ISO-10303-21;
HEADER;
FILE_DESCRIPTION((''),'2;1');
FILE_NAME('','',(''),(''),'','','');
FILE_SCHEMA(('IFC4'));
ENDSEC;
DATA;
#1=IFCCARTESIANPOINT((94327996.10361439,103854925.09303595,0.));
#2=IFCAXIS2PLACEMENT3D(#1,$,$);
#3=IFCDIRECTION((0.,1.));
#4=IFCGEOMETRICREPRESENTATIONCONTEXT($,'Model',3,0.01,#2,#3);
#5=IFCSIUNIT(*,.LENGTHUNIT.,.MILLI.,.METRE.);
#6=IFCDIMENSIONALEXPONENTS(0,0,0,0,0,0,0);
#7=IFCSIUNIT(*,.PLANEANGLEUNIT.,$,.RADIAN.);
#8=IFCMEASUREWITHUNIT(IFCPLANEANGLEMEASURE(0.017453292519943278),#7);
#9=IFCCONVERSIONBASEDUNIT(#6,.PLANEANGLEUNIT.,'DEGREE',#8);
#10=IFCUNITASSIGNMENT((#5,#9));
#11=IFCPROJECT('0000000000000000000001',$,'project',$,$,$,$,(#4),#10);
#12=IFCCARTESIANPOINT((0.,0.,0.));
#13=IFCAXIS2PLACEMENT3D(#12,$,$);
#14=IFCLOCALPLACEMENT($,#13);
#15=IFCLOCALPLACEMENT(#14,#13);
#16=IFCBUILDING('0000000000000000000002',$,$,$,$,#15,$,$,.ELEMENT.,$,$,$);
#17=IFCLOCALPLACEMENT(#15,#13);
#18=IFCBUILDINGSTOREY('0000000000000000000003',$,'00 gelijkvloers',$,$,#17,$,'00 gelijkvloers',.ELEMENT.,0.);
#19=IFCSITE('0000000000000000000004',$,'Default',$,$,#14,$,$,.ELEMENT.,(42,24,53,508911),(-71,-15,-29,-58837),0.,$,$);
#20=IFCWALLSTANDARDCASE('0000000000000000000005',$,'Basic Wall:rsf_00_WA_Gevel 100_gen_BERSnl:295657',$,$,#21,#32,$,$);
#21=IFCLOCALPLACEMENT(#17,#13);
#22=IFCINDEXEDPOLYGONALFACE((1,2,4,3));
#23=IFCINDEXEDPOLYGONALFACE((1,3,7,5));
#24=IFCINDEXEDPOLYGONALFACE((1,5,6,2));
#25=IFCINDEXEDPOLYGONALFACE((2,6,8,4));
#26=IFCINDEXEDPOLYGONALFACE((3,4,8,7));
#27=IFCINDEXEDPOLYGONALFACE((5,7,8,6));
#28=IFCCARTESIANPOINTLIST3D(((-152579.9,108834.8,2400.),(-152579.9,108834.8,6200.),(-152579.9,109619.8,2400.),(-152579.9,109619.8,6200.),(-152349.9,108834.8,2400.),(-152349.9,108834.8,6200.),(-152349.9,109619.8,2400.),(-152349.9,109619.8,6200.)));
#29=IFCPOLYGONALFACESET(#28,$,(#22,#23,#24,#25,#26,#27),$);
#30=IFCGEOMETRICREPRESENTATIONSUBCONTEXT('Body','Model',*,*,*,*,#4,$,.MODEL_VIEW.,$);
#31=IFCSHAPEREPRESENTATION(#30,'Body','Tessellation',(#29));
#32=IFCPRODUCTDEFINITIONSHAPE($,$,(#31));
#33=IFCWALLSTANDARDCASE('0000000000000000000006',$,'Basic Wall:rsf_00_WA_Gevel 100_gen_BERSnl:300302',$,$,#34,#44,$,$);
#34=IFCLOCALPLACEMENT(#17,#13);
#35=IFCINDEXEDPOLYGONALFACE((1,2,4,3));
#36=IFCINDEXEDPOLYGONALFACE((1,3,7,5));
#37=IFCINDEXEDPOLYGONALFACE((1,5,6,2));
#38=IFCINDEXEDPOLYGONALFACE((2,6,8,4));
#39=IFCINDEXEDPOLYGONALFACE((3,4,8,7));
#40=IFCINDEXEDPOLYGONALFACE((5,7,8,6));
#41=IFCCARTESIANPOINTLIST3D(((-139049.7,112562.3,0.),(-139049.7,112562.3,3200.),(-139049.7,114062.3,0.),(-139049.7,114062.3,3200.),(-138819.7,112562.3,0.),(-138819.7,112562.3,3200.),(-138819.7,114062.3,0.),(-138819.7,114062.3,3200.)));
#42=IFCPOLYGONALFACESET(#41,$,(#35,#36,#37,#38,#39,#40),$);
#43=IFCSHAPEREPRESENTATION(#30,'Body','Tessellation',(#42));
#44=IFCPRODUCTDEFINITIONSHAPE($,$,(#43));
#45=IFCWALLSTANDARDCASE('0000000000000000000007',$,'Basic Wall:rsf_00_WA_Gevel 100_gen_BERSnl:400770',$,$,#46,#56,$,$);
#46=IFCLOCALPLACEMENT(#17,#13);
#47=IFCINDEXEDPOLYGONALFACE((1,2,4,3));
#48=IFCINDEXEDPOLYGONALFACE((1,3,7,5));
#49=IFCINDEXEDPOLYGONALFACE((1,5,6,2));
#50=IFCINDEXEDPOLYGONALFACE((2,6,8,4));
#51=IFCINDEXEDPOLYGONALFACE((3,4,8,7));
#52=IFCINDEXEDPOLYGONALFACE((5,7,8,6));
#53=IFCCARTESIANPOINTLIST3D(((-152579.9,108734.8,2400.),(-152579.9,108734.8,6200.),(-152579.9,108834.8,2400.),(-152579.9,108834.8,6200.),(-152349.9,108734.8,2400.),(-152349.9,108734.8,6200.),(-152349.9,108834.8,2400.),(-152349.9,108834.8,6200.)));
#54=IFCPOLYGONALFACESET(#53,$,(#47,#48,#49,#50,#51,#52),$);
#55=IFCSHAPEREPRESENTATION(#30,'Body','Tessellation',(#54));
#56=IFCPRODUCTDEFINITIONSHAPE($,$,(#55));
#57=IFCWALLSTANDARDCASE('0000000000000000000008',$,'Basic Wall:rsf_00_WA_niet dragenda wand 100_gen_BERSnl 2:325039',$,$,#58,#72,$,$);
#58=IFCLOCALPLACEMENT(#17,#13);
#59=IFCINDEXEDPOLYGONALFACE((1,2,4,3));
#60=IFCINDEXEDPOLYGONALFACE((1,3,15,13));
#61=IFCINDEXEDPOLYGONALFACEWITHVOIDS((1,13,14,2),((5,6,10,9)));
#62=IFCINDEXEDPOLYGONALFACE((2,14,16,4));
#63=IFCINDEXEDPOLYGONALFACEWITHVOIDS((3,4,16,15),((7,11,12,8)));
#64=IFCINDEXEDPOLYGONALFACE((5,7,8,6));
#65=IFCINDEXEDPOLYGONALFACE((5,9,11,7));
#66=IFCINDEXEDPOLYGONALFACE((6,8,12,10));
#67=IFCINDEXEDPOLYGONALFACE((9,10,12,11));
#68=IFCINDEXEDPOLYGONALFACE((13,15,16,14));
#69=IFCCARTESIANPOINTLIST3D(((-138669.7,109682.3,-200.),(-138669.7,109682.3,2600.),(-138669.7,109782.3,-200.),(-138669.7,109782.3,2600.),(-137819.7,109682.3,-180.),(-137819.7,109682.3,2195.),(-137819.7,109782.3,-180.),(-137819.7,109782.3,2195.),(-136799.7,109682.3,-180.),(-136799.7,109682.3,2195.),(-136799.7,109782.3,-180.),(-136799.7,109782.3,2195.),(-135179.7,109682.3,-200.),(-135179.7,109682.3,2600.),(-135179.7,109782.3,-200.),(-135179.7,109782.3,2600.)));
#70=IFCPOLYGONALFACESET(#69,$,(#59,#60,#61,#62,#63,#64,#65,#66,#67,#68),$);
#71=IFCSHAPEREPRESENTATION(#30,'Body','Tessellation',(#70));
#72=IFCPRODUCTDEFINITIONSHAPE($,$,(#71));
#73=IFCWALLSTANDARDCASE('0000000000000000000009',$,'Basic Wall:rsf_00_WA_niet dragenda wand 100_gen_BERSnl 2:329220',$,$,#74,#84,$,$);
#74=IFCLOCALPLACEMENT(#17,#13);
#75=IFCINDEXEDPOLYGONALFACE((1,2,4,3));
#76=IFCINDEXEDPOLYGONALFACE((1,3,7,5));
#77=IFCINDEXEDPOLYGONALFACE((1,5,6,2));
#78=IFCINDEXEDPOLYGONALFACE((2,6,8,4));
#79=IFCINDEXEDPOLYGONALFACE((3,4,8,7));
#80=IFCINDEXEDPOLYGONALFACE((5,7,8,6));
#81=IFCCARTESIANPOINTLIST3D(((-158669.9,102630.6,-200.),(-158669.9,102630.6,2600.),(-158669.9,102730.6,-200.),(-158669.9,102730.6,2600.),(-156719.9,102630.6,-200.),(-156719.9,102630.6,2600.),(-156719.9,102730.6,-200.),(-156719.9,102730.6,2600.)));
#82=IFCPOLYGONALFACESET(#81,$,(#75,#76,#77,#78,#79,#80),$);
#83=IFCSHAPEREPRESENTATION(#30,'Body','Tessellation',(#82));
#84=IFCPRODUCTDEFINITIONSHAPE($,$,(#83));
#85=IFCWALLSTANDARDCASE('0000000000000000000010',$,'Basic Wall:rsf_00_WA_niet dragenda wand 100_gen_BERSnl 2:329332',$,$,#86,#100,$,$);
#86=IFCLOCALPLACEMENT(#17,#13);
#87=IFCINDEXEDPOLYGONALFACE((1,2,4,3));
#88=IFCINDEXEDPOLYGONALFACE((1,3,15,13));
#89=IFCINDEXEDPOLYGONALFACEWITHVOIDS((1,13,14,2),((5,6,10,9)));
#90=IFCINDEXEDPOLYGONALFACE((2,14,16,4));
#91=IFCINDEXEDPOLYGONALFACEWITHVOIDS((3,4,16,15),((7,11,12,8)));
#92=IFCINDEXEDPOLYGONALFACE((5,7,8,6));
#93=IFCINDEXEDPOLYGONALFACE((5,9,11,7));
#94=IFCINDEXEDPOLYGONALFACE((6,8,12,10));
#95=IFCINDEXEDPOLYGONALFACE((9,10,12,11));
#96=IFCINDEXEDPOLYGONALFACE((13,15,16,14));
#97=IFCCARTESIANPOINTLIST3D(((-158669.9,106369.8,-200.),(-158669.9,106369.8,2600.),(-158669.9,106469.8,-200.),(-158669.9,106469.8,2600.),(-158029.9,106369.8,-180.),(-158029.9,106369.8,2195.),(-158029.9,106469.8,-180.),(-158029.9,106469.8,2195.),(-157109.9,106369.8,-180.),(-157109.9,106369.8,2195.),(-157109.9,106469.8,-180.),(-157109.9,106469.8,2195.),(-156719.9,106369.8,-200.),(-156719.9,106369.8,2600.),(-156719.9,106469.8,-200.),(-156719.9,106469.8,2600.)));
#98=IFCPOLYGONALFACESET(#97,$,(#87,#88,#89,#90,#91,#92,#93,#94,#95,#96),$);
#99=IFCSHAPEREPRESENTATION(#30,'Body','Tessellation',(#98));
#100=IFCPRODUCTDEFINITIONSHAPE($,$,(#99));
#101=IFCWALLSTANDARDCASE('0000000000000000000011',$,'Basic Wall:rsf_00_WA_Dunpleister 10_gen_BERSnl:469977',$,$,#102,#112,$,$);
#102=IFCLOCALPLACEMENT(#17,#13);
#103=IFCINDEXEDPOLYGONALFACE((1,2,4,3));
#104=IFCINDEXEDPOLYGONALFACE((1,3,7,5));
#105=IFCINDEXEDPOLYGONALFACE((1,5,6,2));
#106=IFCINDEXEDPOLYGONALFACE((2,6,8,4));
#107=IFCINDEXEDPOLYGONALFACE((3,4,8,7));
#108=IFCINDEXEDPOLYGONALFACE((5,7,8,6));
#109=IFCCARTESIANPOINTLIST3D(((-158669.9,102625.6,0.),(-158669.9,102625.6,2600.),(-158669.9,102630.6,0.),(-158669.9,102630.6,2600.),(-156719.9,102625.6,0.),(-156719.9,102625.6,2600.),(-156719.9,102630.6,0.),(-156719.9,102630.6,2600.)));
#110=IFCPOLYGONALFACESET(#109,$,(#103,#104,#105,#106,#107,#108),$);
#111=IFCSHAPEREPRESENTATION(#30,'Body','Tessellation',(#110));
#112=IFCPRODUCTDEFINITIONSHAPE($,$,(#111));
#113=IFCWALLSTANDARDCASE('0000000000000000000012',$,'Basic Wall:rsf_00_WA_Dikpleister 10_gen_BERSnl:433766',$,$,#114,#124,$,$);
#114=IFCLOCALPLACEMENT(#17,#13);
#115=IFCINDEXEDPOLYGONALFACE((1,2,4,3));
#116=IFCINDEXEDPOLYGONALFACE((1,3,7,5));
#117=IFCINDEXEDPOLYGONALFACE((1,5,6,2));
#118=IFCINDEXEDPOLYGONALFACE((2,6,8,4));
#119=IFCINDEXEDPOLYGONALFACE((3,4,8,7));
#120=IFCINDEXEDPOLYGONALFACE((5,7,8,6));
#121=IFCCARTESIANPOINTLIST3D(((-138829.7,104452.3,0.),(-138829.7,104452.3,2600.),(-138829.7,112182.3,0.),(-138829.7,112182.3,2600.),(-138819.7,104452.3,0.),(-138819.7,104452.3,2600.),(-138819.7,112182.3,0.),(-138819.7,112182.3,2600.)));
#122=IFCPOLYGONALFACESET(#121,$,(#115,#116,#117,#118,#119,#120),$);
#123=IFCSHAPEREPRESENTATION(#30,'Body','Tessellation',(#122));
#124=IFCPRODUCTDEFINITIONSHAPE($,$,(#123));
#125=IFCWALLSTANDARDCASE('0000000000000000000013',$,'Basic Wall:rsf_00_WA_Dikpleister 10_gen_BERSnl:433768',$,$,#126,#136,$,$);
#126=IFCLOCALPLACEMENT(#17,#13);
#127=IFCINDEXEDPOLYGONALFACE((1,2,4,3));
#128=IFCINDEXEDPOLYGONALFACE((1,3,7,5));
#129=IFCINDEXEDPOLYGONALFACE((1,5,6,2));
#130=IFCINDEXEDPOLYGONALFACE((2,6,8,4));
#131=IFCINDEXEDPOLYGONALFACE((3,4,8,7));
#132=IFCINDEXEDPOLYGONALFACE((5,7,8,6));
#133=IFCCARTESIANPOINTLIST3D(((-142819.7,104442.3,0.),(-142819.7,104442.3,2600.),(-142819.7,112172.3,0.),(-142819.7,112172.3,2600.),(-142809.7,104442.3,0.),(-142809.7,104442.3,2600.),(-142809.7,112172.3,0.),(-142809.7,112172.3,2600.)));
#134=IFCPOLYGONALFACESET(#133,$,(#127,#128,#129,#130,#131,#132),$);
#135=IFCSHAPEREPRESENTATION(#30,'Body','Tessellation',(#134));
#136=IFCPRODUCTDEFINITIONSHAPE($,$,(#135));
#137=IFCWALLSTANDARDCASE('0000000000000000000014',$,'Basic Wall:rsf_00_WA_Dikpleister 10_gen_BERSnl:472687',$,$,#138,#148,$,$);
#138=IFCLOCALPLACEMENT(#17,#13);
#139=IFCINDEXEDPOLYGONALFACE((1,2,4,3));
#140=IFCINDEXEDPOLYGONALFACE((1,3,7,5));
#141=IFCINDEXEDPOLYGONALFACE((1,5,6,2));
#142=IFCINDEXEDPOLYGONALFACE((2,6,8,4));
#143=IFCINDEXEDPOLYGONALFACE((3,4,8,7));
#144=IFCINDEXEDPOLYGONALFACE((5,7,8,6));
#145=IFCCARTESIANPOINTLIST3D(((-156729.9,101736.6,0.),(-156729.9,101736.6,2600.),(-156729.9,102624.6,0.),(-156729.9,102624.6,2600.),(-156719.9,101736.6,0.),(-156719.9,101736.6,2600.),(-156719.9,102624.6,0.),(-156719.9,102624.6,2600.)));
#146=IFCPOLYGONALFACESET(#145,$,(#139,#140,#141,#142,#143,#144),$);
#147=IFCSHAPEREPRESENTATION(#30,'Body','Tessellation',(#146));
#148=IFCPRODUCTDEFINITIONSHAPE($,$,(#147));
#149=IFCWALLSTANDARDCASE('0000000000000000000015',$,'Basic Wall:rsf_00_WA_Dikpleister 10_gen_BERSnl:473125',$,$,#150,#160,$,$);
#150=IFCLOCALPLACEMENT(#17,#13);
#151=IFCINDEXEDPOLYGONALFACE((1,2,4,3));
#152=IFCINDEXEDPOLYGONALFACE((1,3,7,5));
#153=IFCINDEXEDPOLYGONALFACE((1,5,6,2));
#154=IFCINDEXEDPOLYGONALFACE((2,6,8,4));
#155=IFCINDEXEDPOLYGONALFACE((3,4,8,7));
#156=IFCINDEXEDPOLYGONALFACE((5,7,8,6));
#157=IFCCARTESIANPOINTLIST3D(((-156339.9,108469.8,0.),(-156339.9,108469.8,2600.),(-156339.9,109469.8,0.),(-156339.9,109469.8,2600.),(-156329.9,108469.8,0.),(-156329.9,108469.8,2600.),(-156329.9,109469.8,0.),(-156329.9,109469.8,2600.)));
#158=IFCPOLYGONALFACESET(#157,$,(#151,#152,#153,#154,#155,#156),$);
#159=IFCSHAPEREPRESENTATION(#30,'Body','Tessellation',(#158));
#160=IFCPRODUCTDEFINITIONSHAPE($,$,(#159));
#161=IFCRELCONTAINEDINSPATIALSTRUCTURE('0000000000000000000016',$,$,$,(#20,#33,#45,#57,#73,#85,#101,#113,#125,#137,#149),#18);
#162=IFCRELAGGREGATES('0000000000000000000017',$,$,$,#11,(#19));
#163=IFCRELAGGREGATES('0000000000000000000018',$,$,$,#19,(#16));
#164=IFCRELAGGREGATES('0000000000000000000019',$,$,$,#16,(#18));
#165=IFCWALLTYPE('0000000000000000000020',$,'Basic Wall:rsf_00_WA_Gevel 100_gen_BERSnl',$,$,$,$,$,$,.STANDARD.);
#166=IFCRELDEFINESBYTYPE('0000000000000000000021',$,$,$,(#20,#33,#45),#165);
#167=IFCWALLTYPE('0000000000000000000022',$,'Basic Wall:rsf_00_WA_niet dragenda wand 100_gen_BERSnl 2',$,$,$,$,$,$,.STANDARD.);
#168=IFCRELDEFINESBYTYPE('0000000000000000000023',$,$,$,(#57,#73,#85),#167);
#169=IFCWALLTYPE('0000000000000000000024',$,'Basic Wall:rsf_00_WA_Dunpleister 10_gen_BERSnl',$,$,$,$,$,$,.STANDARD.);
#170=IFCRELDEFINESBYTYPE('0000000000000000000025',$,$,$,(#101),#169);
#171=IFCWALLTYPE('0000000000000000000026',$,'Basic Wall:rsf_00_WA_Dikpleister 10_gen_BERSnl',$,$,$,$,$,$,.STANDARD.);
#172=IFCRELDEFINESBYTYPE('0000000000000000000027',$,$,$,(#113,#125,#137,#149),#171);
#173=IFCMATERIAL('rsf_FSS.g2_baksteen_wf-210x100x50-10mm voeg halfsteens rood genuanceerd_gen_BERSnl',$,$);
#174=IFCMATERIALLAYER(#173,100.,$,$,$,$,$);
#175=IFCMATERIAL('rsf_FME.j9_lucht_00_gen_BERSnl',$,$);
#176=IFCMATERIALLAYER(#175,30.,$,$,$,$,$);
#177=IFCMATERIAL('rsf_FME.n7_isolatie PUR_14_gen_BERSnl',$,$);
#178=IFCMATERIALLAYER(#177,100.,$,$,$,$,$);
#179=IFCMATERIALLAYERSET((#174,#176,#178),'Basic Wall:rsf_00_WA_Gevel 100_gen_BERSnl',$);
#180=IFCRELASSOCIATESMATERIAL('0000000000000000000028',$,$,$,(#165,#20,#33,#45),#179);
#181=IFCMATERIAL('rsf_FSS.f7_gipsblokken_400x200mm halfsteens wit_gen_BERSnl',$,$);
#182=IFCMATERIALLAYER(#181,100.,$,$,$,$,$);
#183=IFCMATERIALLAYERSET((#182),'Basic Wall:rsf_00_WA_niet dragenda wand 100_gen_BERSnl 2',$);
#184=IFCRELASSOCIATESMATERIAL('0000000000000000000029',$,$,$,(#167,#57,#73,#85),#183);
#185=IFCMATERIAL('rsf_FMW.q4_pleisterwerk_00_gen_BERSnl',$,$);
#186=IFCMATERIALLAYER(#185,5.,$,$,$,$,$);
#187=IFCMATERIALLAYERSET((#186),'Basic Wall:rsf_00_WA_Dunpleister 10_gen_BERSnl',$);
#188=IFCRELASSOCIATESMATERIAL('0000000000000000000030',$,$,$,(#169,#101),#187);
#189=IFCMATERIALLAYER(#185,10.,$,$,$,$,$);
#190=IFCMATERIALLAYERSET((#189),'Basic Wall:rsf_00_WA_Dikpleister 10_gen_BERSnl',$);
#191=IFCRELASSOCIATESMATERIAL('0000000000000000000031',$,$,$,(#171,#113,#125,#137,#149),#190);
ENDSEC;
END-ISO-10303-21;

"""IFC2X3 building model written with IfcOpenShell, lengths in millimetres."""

from ifc_helpers import new_model, entity, si_unit, converted_unit, direction, frame, frame_2d, origin, place, context, subcontext, project, spatial, rectangle, extrude, material, layer, layer_set, layer_usage, type_object, element, save


model = new_model("IFC2X3")

# Units and contexts
model_context = context("Model", 3, precision=0.01, world=frame((94327996.10361439, 103854925.09303595, 0.0)), true_north=direction((0.0, 1.0)))
body_context = subcontext(model_context, "Body", "Model", "MODEL_VIEW")
ifc_project = project(units=[si_unit("LENGTHUNIT", "METRE", prefix="MILLI"), converted_unit("PLANEANGLEUNIT", "DEGREE", entity("IfcPlaneAngleMeasure", 0.017453292519943278), si_unit("PLANEANGLEUNIT", "RADIAN"), dimensions=[0, 0, 0, 0, 0, 0, 0])], contexts=[model_context])

# Site, building, storey
site_placement = place(None, origin())
site = spatial("IfcSite", under=ifc_project, at=site_placement, Name="Default", CompositionType="ELEMENT", RefLatitude=(42, 24, 53, 508911), RefLongitude=(-71, -15, -29, -58837), RefElevation=0.0)
building_placement = place(site_placement, origin())
building = spatial("IfcBuilding", under=site, at=building_placement, CompositionType="ELEMENT")
storey_placement = place(building_placement, origin())
storey = spatial("IfcBuildingStorey", under=building, at=storey_placement, Name="00 gelijkvloers", LongName="00 gelijkvloers", CompositionType="ELEMENT", Elevation=0.0)

# Walls
ifc_material_1 = material(Name="rsf_FSS.g2_baksteen_wf-210x100x50-10mm voeg halfsteens rood genuanceerd_gen_BERSnl")
ifc_layer_1 = layer(ifc_material_1, 100.0)
ifc_material_2 = material(Name="rsf_FME.j9_lucht_00_gen_BERSnl")
ifc_layer_2 = layer(ifc_material_2, 30.0)
ifc_material_3 = material(Name="rsf_FME.n7_isolatie PUR_14_gen_BERSnl")
ifc_layer_3 = layer(ifc_material_3, 100.0)
ifc_layer_set_1 = layer_set([ifc_layer_1, ifc_layer_2, ifc_layer_3], Name="Basic Wall:rsf_00_WA_Gevel 100_gen_BERSnl")
ifc_layer_usage_1 = layer_usage(ifc_layer_set_1, "AXIS2", "NEGATIVE", 115.0)
wall_type_1 = type_object("IfcWallType", Name="Basic Wall:rsf_00_WA_Gevel 100_gen_BERSnl", PredefinedType="STANDARD", material=ifc_layer_set_1)
wall_1_placement = place(storey_placement, frame((-152464.9, 109619.8, 2400.0), z_axis=(0.0, 0.0, 1.0), x_axis=(0.0, -1.0, 0.0)))
element("IfcWallStandardCase", 1, at=wall_1_placement, inside=storey, type_object=wall_type_1, material=ifc_layer_usage_1, Name="Basic Wall:rsf_00_WA_Gevel 100_gen_BERSnl:295657", context=body_context, shape_type="SweptSolid", body=[
    extrude(rectangle(XDim=785.0, YDim=230.0, at=frame_2d((392.5, 0.0), x_axis=(-1.0, 0.0))), origin(), (0.0, 0.0, 1.0), 3800.0),
])
ifc_layer_usage_2 = layer_usage(ifc_layer_set_1, "AXIS2", "NEGATIVE", 115.0)
wall_2_placement = place(storey_placement, frame((-138934.7, 112562.3, 0.0), z_axis=(0.0, 0.0, 1.0), x_axis=(0.0, 1.0, 0.0)))
element("IfcWallStandardCase", 2, at=wall_2_placement, inside=storey, type_object=wall_type_1, material=ifc_layer_usage_2, Name="Basic Wall:rsf_00_WA_Gevel 100_gen_BERSnl:300302", context=body_context, shape_type="SweptSolid", body=[
    extrude(rectangle(XDim=1500.0, YDim=230.0, at=frame_2d((750.0, 0.0), x_axis=(-1.0, 0.0))), origin(), (0.0, 0.0, 1.0), 3200.0),
])
ifc_layer_usage_3 = layer_usage(ifc_layer_set_1, "AXIS2", "NEGATIVE", 115.0)
wall_3_placement = place(storey_placement, frame((-152464.9, 108834.8, 2400.0), z_axis=(0.0, 0.0, 1.0), x_axis=(0.0, -1.0, 0.0)))
element("IfcWallStandardCase", 3, at=wall_3_placement, inside=storey, type_object=wall_type_1, material=ifc_layer_usage_3, Name="Basic Wall:rsf_00_WA_Gevel 100_gen_BERSnl:400770", context=body_context, shape_type="SweptSolid", body=[
    extrude(rectangle(XDim=100.0, YDim=230.0, at=frame_2d((50.0, 0.0), x_axis=(-1.0, 0.0))), origin(), (0.0, 0.0, 1.0), 3800.0),
])

# Wall, opening
ifc_material_4 = material(Name="rsf_FSS.f7_gipsblokken_400x200mm halfsteens wit_gen_BERSnl")
ifc_layer_4 = layer(ifc_material_4, 100.0)
ifc_layer_set_2 = layer_set([ifc_layer_4], Name="Basic Wall:rsf_00_WA_niet dragenda wand 100_gen_BERSnl 2")
ifc_layer_usage_4 = layer_usage(ifc_layer_set_2, "AXIS2", "NEGATIVE", 50.0)
wall_type_2 = type_object("IfcWallType", Name="Basic Wall:rsf_00_WA_niet dragenda wand 100_gen_BERSnl 2", PredefinedType="STANDARD", material=ifc_layer_set_2)
wall_4_placement = place(storey_placement, frame((-138669.7, 109732.3, -200.0)))
wall_4 = element("IfcWallStandardCase", 4, at=wall_4_placement, inside=storey, type_object=wall_type_2, material=ifc_layer_usage_4, Name="Basic Wall:rsf_00_WA_niet dragenda wand 100_gen_BERSnl 2:325039", context=body_context, shape_type="SweptSolid", body=[
    extrude(rectangle(XDim=3490.0, YDim=100.0, at=frame_2d((1745.0, 0.0), x_axis=(-1.0, 0.0))), origin(), (0.0, 0.0, 1.0), 2800.0),
])
opening_1_placement = place(wall_4_placement, frame((850.0, -50.0, 20.0)))
element("IfcOpeningElement", 5, at=opening_1_placement, cuts=wall_4, ObjectType="Opening", context=body_context, shape_type="SweptSolid", body=[
    extrude(rectangle(XDim=2375.0, YDim=1020.0, at=frame_2d((1187.5, 510.0), x_axis=(-1.0, 0.0))), frame((0.0, 0.0, 0.0), z_axis=(0.0, 1.0, 0.0), x_axis=(0.0, 0.0, 1.0)), (0.0, 0.0, 1.0), 100.0),
])

# Wall
ifc_layer_usage_5 = layer_usage(ifc_layer_set_2, "AXIS2", "POSITIVE", -50.0)
wall_5_placement = place(storey_placement, frame((-156719.9, 102680.6, -200.0), z_axis=(0.0, 0.0, 1.0), x_axis=(-1.0, 0.0, 0.0)))
element("IfcWallStandardCase", 6, at=wall_5_placement, inside=storey, type_object=wall_type_2, material=ifc_layer_usage_5, Name="Basic Wall:rsf_00_WA_niet dragenda wand 100_gen_BERSnl 2:329220", context=body_context, shape_type="SweptSolid", body=[
    extrude(rectangle(XDim=1950.0, YDim=100.0, at=frame_2d((975.0, 0.0), x_axis=(-1.0, 0.0))), origin(), (0.0, 0.0, 1.0), 2800.0),
])

# Wall, opening
ifc_layer_usage_6 = layer_usage(ifc_layer_set_2, "AXIS2", "POSITIVE", -50.0)
wall_6_placement = place(storey_placement, frame((-156719.9, 106419.8, -200.0), z_axis=(0.0, 0.0, 1.0), x_axis=(-1.0, 0.0, 0.0)))
wall_6 = element("IfcWallStandardCase", 7, at=wall_6_placement, inside=storey, type_object=wall_type_2, material=ifc_layer_usage_6, Name="Basic Wall:rsf_00_WA_niet dragenda wand 100_gen_BERSnl 2:329332", context=body_context, shape_type="SweptSolid", body=[
    extrude(rectangle(XDim=1950.0, YDim=100.0, at=frame_2d((975.0, 0.0), x_axis=(-1.0, 0.0))), origin(), (0.0, 0.0, 1.0), 2800.0),
])
opening_2_placement = place(wall_6_placement, frame((1310.0, 50.0, 20.0)))
element("IfcOpeningElement", 8, at=opening_2_placement, cuts=wall_6, ObjectType="Opening", context=body_context, shape_type="SweptSolid", body=[
    extrude(rectangle(XDim=2375.0, YDim=920.0, at=frame_2d((1187.5, 460.0), x_axis=(-1.0, 0.0))), frame((0.0, 0.0, 0.0), z_axis=(0.0, -1.0, 0.0), x_axis=(0.0, 0.0, 1.0)), (0.0, 0.0, 1.0), 100.0),
])

# Wall
ifc_material_5 = material(Name="rsf_FMW.q4_pleisterwerk_00_gen_BERSnl")
ifc_layer_5 = layer(ifc_material_5, 5.0)
ifc_layer_set_3 = layer_set([ifc_layer_5], Name="Basic Wall:rsf_00_WA_Dunpleister 10_gen_BERSnl")
ifc_layer_usage_7 = layer_usage(ifc_layer_set_3, "AXIS2", "NEGATIVE", 2.5)
wall_type_3 = type_object("IfcWallType", Name="Basic Wall:rsf_00_WA_Dunpleister 10_gen_BERSnl", PredefinedType="STANDARD", material=ifc_layer_set_3)
wall_7_placement = place(storey_placement, frame((-156719.9, 102628.1, 0.0), z_axis=(0.0, 0.0, 1.0), x_axis=(-1.0, 0.0, 0.0)))
element("IfcWallStandardCase", 9, at=wall_7_placement, inside=storey, type_object=wall_type_3, material=ifc_layer_usage_7, Name="Basic Wall:rsf_00_WA_Dunpleister 10_gen_BERSnl:469977", context=body_context, shape_type="SweptSolid", body=[
    extrude(rectangle(XDim=1950.0, YDim=5.0, at=frame_2d((975.0, 0.0), x_axis=(-1.0, 0.0))), origin(), (0.0, 0.0, 1.0), 2600.0),
])

# Walls
ifc_layer_6 = layer(ifc_material_5, 10.0)
ifc_layer_set_4 = layer_set([ifc_layer_6], Name="Basic Wall:rsf_00_WA_Dikpleister 10_gen_BERSnl")
ifc_layer_usage_8 = layer_usage(ifc_layer_set_4, "AXIS2", "POSITIVE", -5.0)
wall_type_4 = type_object("IfcWallType", Name="Basic Wall:rsf_00_WA_Dikpleister 10_gen_BERSnl", PredefinedType="STANDARD", material=ifc_layer_set_4)
wall_8_placement = place(storey_placement, frame((-138824.7, 112182.3, 0.0), z_axis=(0.0, 0.0, 1.0), x_axis=(0.0, -1.0, 0.0)))
element("IfcWallStandardCase", 10, at=wall_8_placement, inside=storey, type_object=wall_type_4, material=ifc_layer_usage_8, Name="Basic Wall:rsf_00_WA_Dikpleister 10_gen_BERSnl:433766", context=body_context, shape_type="SweptSolid", body=[
    extrude(rectangle(XDim=7730.0, YDim=10.0, at=frame_2d((3865.0, 0.0), x_axis=(-1.0, 0.0))), origin(), (0.0, 0.0, 1.0), 2600.0),
])
ifc_layer_usage_9 = layer_usage(ifc_layer_set_4, "AXIS2", "POSITIVE", -5.0)
wall_9_placement = place(storey_placement, frame((-142814.7, 104442.3, 0.0), z_axis=(0.0, 0.0, 1.0), x_axis=(0.0, 1.0, 0.0)))
element("IfcWallStandardCase", 11, at=wall_9_placement, inside=storey, type_object=wall_type_4, material=ifc_layer_usage_9, Name="Basic Wall:rsf_00_WA_Dikpleister 10_gen_BERSnl:433768", context=body_context, shape_type="SweptSolid", body=[
    extrude(rectangle(XDim=7730.0, YDim=10.0, at=frame_2d((3865.0, 0.0), x_axis=(-1.0, 0.0))), origin(), (0.0, 0.0, 1.0), 2600.0),
])

# Walls
ifc_layer_usage_10 = layer_usage(ifc_layer_set_4, "AXIS2", "NEGATIVE", 5.0)
wall_10_placement = place(storey_placement, frame((-156724.9, 101736.6, 0.0), z_axis=(0.0, 0.0, 1.0), x_axis=(0.0, 1.0, 0.0)))
element("IfcWallStandardCase", 12, at=wall_10_placement, inside=storey, type_object=wall_type_4, material=ifc_layer_usage_10, Name="Basic Wall:rsf_00_WA_Dikpleister 10_gen_BERSnl:472687", context=body_context, shape_type="SweptSolid", body=[
    extrude(rectangle(XDim=888.0, YDim=10.0, at=frame_2d((444.0, 0.0), x_axis=(-1.0, 0.0))), origin(), (0.0, 0.0, 1.0), 2600.0),
])
ifc_layer_usage_11 = layer_usage(ifc_layer_set_4, "AXIS2", "NEGATIVE", 5.0)
wall_11_placement = place(storey_placement, frame((-156334.9, 108469.8, 0.0), z_axis=(0.0, 0.0, 1.0), x_axis=(0.0, 1.0, 0.0)))
element("IfcWallStandardCase", 13, at=wall_11_placement, inside=storey, type_object=wall_type_4, material=ifc_layer_usage_11, Name="Basic Wall:rsf_00_WA_Dikpleister 10_gen_BERSnl:473125", context=body_context, shape_type="SweptSolid", body=[
    extrude(rectangle(XDim=1000.0, YDim=10.0, at=frame_2d((500.0, 0.0), x_axis=(-1.0, 0.0))), origin(), (0.0, 0.0, 1.0), 2600.0),
])

save(model, "model.ifc")
